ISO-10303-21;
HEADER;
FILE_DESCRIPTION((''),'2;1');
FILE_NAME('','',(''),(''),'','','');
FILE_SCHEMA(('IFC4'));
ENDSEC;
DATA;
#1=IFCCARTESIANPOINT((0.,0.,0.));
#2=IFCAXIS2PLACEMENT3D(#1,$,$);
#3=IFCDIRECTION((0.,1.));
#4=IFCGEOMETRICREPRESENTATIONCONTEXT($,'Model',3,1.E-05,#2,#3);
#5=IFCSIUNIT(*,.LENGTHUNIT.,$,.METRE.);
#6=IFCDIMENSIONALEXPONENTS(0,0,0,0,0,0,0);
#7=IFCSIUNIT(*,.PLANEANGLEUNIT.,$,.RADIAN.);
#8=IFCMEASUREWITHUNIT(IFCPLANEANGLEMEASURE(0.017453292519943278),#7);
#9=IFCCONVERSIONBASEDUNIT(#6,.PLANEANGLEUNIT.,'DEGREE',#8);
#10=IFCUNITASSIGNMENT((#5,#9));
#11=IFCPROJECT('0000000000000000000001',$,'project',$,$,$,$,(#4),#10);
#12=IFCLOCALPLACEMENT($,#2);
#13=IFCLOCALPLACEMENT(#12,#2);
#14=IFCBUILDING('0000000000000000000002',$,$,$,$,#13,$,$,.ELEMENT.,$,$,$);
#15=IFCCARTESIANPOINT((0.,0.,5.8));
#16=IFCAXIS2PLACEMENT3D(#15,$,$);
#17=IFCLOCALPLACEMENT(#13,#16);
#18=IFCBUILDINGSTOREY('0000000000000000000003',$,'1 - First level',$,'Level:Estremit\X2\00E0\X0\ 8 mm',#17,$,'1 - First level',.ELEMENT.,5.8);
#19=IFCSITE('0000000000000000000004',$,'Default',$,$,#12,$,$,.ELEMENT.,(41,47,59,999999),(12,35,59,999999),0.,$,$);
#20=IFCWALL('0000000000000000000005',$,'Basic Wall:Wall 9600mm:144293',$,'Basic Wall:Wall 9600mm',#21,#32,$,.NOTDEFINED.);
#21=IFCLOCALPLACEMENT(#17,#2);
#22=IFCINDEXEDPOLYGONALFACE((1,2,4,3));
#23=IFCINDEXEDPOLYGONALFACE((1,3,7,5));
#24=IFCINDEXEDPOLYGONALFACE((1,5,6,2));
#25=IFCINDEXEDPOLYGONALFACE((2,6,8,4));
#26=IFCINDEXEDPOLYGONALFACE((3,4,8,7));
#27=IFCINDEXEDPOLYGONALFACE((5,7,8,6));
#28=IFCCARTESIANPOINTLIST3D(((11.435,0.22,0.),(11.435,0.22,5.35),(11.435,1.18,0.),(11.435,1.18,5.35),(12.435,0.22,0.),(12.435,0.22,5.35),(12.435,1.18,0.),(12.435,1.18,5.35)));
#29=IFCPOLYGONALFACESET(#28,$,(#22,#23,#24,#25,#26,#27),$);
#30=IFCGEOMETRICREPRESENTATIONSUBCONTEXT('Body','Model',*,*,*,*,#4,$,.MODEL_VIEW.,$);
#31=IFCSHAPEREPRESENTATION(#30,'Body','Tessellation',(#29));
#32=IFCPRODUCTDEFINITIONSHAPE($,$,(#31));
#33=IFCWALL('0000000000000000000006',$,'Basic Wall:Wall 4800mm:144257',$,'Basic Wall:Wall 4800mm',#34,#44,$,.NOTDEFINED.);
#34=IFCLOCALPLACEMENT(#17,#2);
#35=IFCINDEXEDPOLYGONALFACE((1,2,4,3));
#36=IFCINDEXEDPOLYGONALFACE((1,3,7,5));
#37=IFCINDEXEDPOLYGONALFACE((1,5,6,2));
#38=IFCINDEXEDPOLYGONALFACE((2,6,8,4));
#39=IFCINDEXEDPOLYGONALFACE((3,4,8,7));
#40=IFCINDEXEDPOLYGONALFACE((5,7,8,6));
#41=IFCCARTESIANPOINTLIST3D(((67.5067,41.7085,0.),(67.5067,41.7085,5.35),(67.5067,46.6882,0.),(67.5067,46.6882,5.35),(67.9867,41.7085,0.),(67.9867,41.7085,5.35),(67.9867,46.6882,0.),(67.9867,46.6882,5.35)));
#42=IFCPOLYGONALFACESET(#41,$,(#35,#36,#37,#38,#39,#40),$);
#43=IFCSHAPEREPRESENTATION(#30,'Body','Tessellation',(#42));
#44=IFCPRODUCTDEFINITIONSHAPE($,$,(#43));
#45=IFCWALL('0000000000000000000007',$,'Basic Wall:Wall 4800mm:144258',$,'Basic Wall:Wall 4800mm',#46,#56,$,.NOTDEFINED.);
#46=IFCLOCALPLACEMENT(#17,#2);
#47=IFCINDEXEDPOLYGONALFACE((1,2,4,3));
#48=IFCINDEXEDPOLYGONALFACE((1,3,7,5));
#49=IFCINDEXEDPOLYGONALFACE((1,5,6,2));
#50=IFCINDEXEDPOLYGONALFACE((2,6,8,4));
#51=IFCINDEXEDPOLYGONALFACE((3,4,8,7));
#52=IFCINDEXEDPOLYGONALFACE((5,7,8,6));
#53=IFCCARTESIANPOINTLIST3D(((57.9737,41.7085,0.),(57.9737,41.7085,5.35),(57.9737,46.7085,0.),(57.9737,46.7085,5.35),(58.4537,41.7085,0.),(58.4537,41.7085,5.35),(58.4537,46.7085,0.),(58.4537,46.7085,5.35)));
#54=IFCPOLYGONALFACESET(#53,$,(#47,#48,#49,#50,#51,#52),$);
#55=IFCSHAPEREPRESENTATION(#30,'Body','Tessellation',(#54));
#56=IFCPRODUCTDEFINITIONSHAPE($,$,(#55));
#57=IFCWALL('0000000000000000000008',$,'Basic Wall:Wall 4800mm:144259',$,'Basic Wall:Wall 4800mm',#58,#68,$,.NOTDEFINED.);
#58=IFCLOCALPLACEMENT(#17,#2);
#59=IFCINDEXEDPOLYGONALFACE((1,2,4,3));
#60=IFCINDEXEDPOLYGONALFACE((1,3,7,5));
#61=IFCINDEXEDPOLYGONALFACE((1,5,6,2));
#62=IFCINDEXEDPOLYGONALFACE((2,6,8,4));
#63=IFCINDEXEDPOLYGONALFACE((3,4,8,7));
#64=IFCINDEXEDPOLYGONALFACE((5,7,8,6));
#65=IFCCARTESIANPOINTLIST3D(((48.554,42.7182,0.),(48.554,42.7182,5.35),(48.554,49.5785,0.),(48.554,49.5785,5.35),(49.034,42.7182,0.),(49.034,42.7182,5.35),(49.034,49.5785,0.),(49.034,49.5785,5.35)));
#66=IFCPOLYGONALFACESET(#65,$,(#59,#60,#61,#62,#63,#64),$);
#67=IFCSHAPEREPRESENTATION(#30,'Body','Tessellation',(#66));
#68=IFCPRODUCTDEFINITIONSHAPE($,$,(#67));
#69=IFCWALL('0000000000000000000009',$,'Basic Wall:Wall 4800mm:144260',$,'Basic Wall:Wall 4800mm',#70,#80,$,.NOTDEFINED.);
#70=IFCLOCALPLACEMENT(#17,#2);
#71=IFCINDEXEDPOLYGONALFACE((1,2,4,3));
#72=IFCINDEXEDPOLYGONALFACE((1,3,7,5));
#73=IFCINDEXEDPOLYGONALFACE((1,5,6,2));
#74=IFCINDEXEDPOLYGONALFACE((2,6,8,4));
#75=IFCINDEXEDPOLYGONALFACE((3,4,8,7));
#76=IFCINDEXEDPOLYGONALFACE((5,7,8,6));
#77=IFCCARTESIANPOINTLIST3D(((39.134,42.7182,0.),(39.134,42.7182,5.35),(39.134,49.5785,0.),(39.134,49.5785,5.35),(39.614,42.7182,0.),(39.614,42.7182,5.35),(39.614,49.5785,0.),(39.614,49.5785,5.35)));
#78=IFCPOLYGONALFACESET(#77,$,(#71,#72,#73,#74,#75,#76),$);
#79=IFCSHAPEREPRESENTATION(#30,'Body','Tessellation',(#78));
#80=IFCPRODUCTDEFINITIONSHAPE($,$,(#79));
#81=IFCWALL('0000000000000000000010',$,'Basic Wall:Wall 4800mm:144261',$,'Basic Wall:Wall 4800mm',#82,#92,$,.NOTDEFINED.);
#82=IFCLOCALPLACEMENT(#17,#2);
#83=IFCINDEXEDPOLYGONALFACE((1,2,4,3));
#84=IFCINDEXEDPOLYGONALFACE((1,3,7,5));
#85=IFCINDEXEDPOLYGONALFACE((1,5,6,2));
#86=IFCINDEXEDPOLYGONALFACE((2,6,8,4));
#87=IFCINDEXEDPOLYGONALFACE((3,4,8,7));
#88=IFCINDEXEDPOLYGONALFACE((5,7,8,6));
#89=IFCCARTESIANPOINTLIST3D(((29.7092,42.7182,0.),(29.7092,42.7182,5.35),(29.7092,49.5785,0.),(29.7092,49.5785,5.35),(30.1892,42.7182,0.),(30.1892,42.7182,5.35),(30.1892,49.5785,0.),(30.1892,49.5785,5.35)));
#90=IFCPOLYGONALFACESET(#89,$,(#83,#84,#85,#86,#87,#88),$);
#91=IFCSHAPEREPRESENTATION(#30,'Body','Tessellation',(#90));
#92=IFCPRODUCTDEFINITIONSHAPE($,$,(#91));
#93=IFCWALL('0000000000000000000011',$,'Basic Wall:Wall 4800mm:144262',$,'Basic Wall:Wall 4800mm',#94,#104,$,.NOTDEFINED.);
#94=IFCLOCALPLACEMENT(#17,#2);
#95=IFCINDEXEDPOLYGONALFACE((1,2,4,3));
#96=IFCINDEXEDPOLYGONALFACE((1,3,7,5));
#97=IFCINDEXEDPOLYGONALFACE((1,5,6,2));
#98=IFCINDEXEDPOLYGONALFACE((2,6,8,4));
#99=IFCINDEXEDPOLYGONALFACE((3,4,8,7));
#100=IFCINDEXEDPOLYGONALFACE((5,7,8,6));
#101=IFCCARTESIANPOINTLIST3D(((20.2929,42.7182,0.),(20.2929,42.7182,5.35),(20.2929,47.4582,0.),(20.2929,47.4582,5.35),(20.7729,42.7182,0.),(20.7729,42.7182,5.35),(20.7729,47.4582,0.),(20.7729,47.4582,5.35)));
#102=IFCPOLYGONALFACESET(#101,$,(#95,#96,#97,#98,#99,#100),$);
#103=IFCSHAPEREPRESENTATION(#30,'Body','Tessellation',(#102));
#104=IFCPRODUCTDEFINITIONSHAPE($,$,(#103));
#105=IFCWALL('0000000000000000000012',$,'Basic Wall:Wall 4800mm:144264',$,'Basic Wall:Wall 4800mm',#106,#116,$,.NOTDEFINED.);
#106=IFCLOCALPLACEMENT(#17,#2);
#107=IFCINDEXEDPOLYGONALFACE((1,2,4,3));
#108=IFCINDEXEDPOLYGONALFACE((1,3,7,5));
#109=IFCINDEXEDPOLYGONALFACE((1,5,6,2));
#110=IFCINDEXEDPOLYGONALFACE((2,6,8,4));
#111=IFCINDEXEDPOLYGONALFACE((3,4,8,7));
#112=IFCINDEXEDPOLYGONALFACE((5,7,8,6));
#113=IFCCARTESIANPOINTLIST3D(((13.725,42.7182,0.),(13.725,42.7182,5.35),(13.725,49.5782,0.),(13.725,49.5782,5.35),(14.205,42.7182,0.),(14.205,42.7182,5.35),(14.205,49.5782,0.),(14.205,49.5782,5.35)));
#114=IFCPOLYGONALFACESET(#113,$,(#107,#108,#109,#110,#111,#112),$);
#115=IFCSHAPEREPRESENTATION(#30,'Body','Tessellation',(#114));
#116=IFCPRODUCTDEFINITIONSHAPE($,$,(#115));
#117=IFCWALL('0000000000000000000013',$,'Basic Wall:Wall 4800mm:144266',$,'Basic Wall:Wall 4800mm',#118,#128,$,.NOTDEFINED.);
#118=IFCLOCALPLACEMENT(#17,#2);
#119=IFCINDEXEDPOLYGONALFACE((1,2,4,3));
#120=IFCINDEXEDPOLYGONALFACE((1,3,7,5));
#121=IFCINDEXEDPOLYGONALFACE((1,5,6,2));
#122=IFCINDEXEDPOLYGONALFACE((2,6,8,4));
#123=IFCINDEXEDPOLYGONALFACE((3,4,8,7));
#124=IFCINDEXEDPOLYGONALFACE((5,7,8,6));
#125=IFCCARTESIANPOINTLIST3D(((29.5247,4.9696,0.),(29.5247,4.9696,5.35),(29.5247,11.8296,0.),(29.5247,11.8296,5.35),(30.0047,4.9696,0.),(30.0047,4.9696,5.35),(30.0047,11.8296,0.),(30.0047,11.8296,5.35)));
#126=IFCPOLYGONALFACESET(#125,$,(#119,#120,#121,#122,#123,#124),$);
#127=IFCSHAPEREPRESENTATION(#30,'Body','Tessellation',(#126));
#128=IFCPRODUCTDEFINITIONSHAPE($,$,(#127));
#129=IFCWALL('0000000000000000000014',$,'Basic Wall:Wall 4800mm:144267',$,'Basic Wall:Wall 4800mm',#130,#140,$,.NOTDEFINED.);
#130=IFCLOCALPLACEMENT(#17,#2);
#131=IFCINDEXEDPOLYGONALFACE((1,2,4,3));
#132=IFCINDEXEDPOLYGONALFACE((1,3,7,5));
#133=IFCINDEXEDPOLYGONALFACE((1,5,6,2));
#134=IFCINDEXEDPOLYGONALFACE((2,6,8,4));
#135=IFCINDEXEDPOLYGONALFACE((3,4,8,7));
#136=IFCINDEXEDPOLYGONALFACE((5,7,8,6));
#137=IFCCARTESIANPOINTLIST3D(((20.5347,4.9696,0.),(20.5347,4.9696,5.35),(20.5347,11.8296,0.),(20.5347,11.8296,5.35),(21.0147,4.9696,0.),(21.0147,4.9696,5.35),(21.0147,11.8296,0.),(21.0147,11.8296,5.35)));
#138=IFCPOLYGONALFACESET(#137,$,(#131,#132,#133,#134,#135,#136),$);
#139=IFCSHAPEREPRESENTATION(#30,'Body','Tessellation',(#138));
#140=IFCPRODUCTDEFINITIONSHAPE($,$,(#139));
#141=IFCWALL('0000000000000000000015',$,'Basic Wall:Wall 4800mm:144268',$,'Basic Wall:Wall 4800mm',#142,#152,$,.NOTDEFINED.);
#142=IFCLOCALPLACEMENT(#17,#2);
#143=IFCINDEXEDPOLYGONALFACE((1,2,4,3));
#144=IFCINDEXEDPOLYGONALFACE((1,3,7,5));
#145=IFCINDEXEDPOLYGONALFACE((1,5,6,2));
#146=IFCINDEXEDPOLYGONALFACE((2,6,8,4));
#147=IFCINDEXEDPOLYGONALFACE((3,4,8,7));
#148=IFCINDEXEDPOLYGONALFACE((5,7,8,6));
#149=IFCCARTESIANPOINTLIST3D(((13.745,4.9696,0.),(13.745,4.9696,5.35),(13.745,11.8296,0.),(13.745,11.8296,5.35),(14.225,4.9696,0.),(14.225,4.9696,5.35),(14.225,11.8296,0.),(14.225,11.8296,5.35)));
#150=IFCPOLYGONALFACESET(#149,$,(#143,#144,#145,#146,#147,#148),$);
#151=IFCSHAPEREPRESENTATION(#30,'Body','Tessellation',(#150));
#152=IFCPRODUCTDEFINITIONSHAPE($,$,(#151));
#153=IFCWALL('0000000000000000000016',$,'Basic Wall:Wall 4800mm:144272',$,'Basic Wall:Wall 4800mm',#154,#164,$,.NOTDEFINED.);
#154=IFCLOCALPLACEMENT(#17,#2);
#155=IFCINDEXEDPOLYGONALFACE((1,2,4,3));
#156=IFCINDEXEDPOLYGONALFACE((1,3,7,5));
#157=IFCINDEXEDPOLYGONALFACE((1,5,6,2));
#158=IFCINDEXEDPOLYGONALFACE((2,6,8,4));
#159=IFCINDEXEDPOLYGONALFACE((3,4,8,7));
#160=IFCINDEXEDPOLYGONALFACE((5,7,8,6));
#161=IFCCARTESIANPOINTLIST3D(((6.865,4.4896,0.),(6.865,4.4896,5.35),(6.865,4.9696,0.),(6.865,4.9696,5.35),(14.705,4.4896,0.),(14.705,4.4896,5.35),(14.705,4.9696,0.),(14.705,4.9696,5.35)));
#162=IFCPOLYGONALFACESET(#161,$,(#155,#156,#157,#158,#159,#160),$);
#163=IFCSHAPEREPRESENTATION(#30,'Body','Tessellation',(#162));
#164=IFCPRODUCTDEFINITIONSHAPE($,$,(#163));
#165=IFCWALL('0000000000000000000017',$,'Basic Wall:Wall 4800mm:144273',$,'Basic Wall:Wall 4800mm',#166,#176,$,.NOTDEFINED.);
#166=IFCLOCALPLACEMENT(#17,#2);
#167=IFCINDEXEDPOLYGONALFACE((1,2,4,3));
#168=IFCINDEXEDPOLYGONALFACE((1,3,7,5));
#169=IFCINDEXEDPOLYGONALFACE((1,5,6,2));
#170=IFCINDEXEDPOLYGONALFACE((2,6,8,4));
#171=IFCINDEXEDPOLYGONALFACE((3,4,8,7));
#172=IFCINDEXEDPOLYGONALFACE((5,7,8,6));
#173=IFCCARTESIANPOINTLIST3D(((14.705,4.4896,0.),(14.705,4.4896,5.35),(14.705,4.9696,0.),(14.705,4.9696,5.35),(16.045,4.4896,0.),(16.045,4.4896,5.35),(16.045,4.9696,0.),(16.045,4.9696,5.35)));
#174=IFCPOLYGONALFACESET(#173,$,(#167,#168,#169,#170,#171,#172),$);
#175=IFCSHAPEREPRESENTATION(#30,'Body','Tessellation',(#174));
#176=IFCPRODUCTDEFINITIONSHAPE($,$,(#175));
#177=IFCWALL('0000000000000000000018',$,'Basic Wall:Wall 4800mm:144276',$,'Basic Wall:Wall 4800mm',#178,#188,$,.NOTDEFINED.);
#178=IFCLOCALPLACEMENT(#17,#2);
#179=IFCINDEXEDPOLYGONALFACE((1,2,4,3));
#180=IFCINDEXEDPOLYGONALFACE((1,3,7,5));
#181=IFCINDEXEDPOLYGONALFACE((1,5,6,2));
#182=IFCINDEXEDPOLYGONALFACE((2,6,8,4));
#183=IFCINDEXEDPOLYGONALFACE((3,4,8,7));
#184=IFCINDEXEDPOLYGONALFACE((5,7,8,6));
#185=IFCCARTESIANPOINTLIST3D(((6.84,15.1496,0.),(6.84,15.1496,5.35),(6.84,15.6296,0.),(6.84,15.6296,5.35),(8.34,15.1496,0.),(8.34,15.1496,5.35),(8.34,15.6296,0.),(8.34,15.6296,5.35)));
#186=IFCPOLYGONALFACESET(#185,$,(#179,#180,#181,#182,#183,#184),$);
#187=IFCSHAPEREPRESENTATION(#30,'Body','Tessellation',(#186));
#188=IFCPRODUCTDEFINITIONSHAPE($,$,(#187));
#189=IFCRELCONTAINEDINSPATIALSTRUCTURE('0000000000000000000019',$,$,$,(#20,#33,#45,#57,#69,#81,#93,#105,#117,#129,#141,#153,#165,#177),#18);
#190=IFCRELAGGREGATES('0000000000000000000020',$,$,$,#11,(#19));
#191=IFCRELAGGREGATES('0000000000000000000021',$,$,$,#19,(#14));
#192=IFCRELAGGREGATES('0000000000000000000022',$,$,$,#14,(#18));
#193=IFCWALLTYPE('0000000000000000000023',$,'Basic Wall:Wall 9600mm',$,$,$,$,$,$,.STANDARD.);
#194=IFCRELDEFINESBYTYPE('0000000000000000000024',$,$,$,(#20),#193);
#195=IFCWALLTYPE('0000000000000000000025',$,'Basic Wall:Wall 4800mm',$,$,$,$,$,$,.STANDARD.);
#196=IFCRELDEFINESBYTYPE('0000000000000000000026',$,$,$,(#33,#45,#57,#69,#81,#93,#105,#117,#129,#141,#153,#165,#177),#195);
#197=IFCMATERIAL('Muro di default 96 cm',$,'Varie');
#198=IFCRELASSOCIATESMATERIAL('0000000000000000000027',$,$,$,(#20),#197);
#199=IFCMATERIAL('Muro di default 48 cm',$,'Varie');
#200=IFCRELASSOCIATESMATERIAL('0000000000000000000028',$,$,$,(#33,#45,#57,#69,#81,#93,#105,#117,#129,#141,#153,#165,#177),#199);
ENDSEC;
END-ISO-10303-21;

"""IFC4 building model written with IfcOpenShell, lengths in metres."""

from ifc_helpers import new_model, entity, si_unit, converted_unit, direction, frame, origin, place, context, subcontext, project, spatial, indexed_curve, outline, extrude, material, type_object, element, save


model = new_model("IFC4")

# Units and contexts
model_context = context("Model", 3, precision=1e-05, world=origin(), true_north=direction((0.0, 1.0)))
body_context = subcontext(model_context, "Body", "Model", "MODEL_VIEW")
ifc_project = project(units=[si_unit("LENGTHUNIT", "METRE"), converted_unit("PLANEANGLEUNIT", "DEGREE", entity("IfcPlaneAngleMeasure", 0.017453292519943278), si_unit("PLANEANGLEUNIT", "RADIAN"), dimensions=[0, 0, 0, 0, 0, 0, 0])], contexts=[model_context])

# Site, building, storey
site_placement = place(None, origin())
site = spatial("IfcSite", under=ifc_project, at=site_placement, Name="Default", CompositionType="ELEMENT", RefLatitude=(41, 47, 59, 999999), RefLongitude=(12, 35, 59, 999999), RefElevation=0.0)
building_placement = place(site_placement, origin())
building = spatial("IfcBuilding", under=site, at=building_placement, CompositionType="ELEMENT")
storey_placement = place(building_placement, frame((0.0, 0.0, 5.8)))
storey = spatial("IfcBuildingStorey", under=building, at=storey_placement, Name="1 - First level", ObjectType="Level:Estremità 8 mm", LongName="1 - First level", CompositionType="ELEMENT", Elevation=5.8)

# Walls
ifc_material_1 = material(Name="Muro di default 96 cm", Category="Varie")
wall_type_1 = type_object("IfcWallType", Name="Basic Wall:Wall 9600mm", PredefinedType="STANDARD")
wall_1_placement = place(storey_placement, frame((12.435, 0.7, 0.0), z_axis=(0.0, 0.0, 1.0), x_axis=(-1.0, 0.0, 0.0)))
element("IfcWall", 1, at=wall_1_placement, inside=storey, type_object=wall_type_1, material=ifc_material_1, Name="Basic Wall:Wall 9600mm:144293", ObjectType="Basic Wall:Wall 9600mm", PredefinedType="NOTDEFINED", context=body_context, shape_type="SweptSolid", body=[
    extrude(outline(indexed_curve([(1.0, 0.48), (0.0, 0.48), (0.0, -0.48), (1.0, -0.48), (1.0, 0.48)], self_intersect=False)), origin(), (0.0, 0.0, 1.0), 5.35),
])
ifc_material_2 = material(Name="Muro di default 48 cm", Category="Varie")
wall_type_2 = type_object("IfcWallType", Name="Basic Wall:Wall 4800mm", PredefinedType="STANDARD")
wall_2_placement = place(storey_placement, frame((67.7467, 41.7085, 0.0), z_axis=(0.0, 0.0, 1.0), x_axis=(0.0, 1.0, 0.0)))
element("IfcWall", 2, at=wall_2_placement, inside=storey, type_object=wall_type_2, material=ifc_material_2, Name="Basic Wall:Wall 4800mm:144257", ObjectType="Basic Wall:Wall 4800mm", PredefinedType="NOTDEFINED", context=body_context, shape_type="SweptSolid", body=[
    extrude(outline(indexed_curve([(4.9797, 0.24), (0.0, 0.24), (0.0, -0.24), (4.9797, -0.24), (4.9797, 0.24)], self_intersect=False)), origin(), (0.0, 0.0, 1.0), 5.35),
])
wall_3_placement = place(storey_placement, frame((58.2137, 41.7085, 0.0), z_axis=(0.0, 0.0, 1.0), x_axis=(0.0, 1.0, 0.0)))
element("IfcWall", 3, at=wall_3_placement, inside=storey, type_object=wall_type_2, material=ifc_material_2, Name="Basic Wall:Wall 4800mm:144258", ObjectType="Basic Wall:Wall 4800mm", PredefinedType="NOTDEFINED", context=body_context, shape_type="SweptSolid", body=[
    extrude(outline(indexed_curve([(5.0, 0.24), (0.0, 0.24), (0.0, -0.24), (5.0, -0.24), (5.0, 0.24)], self_intersect=False)), origin(), (0.0, 0.0, 1.0), 5.35),
])
for number, where, z_axis, x_axis, name in (
    (4, (48.794, 42.7182, 0.0), (0.0, 0.0, 1.0), (0.0, 1.0, 0.0), "Basic Wall:Wall 4800mm:144259"),
    (5, (39.374, 42.7182, 0.0), (0.0, 0.0, 1.0), (0.0, 1.0, 0.0), "Basic Wall:Wall 4800mm:144260"),
):
    element("IfcWall", number, at=place(storey_placement, frame(where, z_axis=z_axis, x_axis=x_axis)), inside=storey, type_object=wall_type_2, material=ifc_material_2, Name=name, ObjectType="Basic Wall:Wall 4800mm", PredefinedType="NOTDEFINED", context=body_context, shape_type="SweptSolid", body=[
        extrude(outline(indexed_curve([(6.8603, 0.24), (0.0, 0.24), (0.0, -0.24), (6.8603, -0.24), (6.8603, 0.24)], self_intersect=False)), origin(), (0.0, 0.0, 1.0), 5.35),
    ])
wall_4_placement = place(storey_placement, frame((29.9492, 42.7182, 0.0), z_axis=(0.0, 0.0, 1.0), x_axis=(0.0, 1.0, 0.0)))
element("IfcWall", 6, at=wall_4_placement, inside=storey, type_object=wall_type_2, material=ifc_material_2, Name="Basic Wall:Wall 4800mm:144261", ObjectType="Basic Wall:Wall 4800mm", PredefinedType="NOTDEFINED", context=body_context, shape_type="SweptSolid", body=[
    extrude(outline(indexed_curve([(6.8603, 0.24), (0.0, 0.24), (0.0, -0.24), (6.8603, -0.24), (6.8603, 0.24)], self_intersect=False)), origin(), (0.0, 0.0, 1.0), 5.35),
])
wall_5_placement = place(storey_placement, frame((20.5329, 42.7182, 0.0), z_axis=(0.0, 0.0, 1.0), x_axis=(0.0, 1.0, 0.0)))
element("IfcWall", 7, at=wall_5_placement, inside=storey, type_object=wall_type_2, material=ifc_material_2, Name="Basic Wall:Wall 4800mm:144262", ObjectType="Basic Wall:Wall 4800mm", PredefinedType="NOTDEFINED", context=body_context, shape_type="SweptSolid", body=[
    extrude(outline(indexed_curve([(4.74, 0.24), (0.0, 0.24), (0.0, -0.24), (4.74, -0.24), (4.74, 0.24)], self_intersect=False)), origin(), (0.0, 0.0, 1.0), 5.35),
])
wall_6_placement = place(storey_placement, frame((13.965, 42.7182, 0.0), z_axis=(0.0, 0.0, 1.0), x_axis=(0.0, 1.0, 0.0)))
element("IfcWall", 8, at=wall_6_placement, inside=storey, type_object=wall_type_2, material=ifc_material_2, Name="Basic Wall:Wall 4800mm:144264", ObjectType="Basic Wall:Wall 4800mm", PredefinedType="NOTDEFINED", context=body_context, shape_type="SweptSolid", body=[
    extrude(outline(indexed_curve([(6.86, 0.24), (0.0, 0.24), (0.0, -0.24), (6.86, -0.24), (6.86, 0.24)], self_intersect=False)), origin(), (0.0, 0.0, 1.0), 5.35),
])
for number, where, z_axis, x_axis, name in (
    (9, (29.7647, 4.9696, 0.0), (0.0, 0.0, 1.0), (0.0, 1.0, 0.0), "Basic Wall:Wall 4800mm:144266"),
    (10, (20.7747, 4.9696, 0.0), (0.0, 0.0, 1.0), (0.0, 1.0, 0.0), "Basic Wall:Wall 4800mm:144267"),
):
    element("IfcWall", number, at=place(storey_placement, frame(where, z_axis=z_axis, x_axis=x_axis)), inside=storey, type_object=wall_type_2, material=ifc_material_2, Name=name, ObjectType="Basic Wall:Wall 4800mm", PredefinedType="NOTDEFINED", context=body_context, shape_type="SweptSolid", body=[
        extrude(outline(indexed_curve([(6.86, 0.24), (0.0, 0.24), (0.0, -0.24), (6.86, -0.24), (6.86, 0.24)], self_intersect=False)), origin(), (0.0, 0.0, 1.0), 5.35),
    ])
wall_7_placement = place(storey_placement, frame((13.985, 4.9696, 0.0), z_axis=(0.0, 0.0, 1.0), x_axis=(0.0, 1.0, 0.0)))
element("IfcWall", 11, at=wall_7_placement, inside=storey, type_object=wall_type_2, material=ifc_material_2, Name="Basic Wall:Wall 4800mm:144268", ObjectType="Basic Wall:Wall 4800mm", PredefinedType="NOTDEFINED", context=body_context, shape_type="SweptSolid", body=[
    extrude(outline(indexed_curve([(6.86, 0.24), (0.0, 0.24), (0.0, -0.24), (6.86, -0.24), (6.86, 0.24)], self_intersect=False)), origin(), (0.0, 0.0, 1.0), 5.35),
])
wall_8_placement = place(storey_placement, frame((6.865, 4.7296, 0.0)))
element("IfcWall", 12, at=wall_8_placement, inside=storey, type_object=wall_type_2, material=ifc_material_2, Name="Basic Wall:Wall 4800mm:144272", ObjectType="Basic Wall:Wall 4800mm", PredefinedType="NOTDEFINED", context=body_context, shape_type="SweptSolid", body=[
    extrude(outline(indexed_curve([(7.84, 0.24), (0.0, 0.24), (0.0, -0.24), (7.84, -0.24), (7.84, 0.24)], self_intersect=False)), origin(), (0.0, 0.0, 1.0), 5.35),
])
wall_9_placement = place(storey_placement, frame((14.705, 4.7296, 0.0)))
element("IfcWall", 13, at=wall_9_placement, inside=storey, type_object=wall_type_2, material=ifc_material_2, Name="Basic Wall:Wall 4800mm:144273", ObjectType="Basic Wall:Wall 4800mm", PredefinedType="NOTDEFINED", context=body_context, shape_type="SweptSolid", body=[
    extrude(outline(indexed_curve([(1.34, 0.24), (0.0, 0.24), (0.0, -0.24), (1.34, -0.24), (1.34, 0.24)], self_intersect=False)), origin(), (0.0, 0.0, 1.0), 5.35),
])
wall_10_placement = place(storey_placement, frame((6.84, 15.3896, 0.0)))
element("IfcWall", 14, at=wall_10_placement, inside=storey, type_object=wall_type_2, material=ifc_material_2, Name="Basic Wall:Wall 4800mm:144276", ObjectType="Basic Wall:Wall 4800mm", PredefinedType="NOTDEFINED", context=body_context, shape_type="SweptSolid", body=[
    extrude(outline(indexed_curve([(1.5, 0.24), (0.0, 0.24), (0.0, -0.24), (1.5, -0.24), (1.5, 0.24)], self_intersect=False)), origin(), (0.0, 0.0, 1.0), 5.35),
])

save(model, "model.ifc")
